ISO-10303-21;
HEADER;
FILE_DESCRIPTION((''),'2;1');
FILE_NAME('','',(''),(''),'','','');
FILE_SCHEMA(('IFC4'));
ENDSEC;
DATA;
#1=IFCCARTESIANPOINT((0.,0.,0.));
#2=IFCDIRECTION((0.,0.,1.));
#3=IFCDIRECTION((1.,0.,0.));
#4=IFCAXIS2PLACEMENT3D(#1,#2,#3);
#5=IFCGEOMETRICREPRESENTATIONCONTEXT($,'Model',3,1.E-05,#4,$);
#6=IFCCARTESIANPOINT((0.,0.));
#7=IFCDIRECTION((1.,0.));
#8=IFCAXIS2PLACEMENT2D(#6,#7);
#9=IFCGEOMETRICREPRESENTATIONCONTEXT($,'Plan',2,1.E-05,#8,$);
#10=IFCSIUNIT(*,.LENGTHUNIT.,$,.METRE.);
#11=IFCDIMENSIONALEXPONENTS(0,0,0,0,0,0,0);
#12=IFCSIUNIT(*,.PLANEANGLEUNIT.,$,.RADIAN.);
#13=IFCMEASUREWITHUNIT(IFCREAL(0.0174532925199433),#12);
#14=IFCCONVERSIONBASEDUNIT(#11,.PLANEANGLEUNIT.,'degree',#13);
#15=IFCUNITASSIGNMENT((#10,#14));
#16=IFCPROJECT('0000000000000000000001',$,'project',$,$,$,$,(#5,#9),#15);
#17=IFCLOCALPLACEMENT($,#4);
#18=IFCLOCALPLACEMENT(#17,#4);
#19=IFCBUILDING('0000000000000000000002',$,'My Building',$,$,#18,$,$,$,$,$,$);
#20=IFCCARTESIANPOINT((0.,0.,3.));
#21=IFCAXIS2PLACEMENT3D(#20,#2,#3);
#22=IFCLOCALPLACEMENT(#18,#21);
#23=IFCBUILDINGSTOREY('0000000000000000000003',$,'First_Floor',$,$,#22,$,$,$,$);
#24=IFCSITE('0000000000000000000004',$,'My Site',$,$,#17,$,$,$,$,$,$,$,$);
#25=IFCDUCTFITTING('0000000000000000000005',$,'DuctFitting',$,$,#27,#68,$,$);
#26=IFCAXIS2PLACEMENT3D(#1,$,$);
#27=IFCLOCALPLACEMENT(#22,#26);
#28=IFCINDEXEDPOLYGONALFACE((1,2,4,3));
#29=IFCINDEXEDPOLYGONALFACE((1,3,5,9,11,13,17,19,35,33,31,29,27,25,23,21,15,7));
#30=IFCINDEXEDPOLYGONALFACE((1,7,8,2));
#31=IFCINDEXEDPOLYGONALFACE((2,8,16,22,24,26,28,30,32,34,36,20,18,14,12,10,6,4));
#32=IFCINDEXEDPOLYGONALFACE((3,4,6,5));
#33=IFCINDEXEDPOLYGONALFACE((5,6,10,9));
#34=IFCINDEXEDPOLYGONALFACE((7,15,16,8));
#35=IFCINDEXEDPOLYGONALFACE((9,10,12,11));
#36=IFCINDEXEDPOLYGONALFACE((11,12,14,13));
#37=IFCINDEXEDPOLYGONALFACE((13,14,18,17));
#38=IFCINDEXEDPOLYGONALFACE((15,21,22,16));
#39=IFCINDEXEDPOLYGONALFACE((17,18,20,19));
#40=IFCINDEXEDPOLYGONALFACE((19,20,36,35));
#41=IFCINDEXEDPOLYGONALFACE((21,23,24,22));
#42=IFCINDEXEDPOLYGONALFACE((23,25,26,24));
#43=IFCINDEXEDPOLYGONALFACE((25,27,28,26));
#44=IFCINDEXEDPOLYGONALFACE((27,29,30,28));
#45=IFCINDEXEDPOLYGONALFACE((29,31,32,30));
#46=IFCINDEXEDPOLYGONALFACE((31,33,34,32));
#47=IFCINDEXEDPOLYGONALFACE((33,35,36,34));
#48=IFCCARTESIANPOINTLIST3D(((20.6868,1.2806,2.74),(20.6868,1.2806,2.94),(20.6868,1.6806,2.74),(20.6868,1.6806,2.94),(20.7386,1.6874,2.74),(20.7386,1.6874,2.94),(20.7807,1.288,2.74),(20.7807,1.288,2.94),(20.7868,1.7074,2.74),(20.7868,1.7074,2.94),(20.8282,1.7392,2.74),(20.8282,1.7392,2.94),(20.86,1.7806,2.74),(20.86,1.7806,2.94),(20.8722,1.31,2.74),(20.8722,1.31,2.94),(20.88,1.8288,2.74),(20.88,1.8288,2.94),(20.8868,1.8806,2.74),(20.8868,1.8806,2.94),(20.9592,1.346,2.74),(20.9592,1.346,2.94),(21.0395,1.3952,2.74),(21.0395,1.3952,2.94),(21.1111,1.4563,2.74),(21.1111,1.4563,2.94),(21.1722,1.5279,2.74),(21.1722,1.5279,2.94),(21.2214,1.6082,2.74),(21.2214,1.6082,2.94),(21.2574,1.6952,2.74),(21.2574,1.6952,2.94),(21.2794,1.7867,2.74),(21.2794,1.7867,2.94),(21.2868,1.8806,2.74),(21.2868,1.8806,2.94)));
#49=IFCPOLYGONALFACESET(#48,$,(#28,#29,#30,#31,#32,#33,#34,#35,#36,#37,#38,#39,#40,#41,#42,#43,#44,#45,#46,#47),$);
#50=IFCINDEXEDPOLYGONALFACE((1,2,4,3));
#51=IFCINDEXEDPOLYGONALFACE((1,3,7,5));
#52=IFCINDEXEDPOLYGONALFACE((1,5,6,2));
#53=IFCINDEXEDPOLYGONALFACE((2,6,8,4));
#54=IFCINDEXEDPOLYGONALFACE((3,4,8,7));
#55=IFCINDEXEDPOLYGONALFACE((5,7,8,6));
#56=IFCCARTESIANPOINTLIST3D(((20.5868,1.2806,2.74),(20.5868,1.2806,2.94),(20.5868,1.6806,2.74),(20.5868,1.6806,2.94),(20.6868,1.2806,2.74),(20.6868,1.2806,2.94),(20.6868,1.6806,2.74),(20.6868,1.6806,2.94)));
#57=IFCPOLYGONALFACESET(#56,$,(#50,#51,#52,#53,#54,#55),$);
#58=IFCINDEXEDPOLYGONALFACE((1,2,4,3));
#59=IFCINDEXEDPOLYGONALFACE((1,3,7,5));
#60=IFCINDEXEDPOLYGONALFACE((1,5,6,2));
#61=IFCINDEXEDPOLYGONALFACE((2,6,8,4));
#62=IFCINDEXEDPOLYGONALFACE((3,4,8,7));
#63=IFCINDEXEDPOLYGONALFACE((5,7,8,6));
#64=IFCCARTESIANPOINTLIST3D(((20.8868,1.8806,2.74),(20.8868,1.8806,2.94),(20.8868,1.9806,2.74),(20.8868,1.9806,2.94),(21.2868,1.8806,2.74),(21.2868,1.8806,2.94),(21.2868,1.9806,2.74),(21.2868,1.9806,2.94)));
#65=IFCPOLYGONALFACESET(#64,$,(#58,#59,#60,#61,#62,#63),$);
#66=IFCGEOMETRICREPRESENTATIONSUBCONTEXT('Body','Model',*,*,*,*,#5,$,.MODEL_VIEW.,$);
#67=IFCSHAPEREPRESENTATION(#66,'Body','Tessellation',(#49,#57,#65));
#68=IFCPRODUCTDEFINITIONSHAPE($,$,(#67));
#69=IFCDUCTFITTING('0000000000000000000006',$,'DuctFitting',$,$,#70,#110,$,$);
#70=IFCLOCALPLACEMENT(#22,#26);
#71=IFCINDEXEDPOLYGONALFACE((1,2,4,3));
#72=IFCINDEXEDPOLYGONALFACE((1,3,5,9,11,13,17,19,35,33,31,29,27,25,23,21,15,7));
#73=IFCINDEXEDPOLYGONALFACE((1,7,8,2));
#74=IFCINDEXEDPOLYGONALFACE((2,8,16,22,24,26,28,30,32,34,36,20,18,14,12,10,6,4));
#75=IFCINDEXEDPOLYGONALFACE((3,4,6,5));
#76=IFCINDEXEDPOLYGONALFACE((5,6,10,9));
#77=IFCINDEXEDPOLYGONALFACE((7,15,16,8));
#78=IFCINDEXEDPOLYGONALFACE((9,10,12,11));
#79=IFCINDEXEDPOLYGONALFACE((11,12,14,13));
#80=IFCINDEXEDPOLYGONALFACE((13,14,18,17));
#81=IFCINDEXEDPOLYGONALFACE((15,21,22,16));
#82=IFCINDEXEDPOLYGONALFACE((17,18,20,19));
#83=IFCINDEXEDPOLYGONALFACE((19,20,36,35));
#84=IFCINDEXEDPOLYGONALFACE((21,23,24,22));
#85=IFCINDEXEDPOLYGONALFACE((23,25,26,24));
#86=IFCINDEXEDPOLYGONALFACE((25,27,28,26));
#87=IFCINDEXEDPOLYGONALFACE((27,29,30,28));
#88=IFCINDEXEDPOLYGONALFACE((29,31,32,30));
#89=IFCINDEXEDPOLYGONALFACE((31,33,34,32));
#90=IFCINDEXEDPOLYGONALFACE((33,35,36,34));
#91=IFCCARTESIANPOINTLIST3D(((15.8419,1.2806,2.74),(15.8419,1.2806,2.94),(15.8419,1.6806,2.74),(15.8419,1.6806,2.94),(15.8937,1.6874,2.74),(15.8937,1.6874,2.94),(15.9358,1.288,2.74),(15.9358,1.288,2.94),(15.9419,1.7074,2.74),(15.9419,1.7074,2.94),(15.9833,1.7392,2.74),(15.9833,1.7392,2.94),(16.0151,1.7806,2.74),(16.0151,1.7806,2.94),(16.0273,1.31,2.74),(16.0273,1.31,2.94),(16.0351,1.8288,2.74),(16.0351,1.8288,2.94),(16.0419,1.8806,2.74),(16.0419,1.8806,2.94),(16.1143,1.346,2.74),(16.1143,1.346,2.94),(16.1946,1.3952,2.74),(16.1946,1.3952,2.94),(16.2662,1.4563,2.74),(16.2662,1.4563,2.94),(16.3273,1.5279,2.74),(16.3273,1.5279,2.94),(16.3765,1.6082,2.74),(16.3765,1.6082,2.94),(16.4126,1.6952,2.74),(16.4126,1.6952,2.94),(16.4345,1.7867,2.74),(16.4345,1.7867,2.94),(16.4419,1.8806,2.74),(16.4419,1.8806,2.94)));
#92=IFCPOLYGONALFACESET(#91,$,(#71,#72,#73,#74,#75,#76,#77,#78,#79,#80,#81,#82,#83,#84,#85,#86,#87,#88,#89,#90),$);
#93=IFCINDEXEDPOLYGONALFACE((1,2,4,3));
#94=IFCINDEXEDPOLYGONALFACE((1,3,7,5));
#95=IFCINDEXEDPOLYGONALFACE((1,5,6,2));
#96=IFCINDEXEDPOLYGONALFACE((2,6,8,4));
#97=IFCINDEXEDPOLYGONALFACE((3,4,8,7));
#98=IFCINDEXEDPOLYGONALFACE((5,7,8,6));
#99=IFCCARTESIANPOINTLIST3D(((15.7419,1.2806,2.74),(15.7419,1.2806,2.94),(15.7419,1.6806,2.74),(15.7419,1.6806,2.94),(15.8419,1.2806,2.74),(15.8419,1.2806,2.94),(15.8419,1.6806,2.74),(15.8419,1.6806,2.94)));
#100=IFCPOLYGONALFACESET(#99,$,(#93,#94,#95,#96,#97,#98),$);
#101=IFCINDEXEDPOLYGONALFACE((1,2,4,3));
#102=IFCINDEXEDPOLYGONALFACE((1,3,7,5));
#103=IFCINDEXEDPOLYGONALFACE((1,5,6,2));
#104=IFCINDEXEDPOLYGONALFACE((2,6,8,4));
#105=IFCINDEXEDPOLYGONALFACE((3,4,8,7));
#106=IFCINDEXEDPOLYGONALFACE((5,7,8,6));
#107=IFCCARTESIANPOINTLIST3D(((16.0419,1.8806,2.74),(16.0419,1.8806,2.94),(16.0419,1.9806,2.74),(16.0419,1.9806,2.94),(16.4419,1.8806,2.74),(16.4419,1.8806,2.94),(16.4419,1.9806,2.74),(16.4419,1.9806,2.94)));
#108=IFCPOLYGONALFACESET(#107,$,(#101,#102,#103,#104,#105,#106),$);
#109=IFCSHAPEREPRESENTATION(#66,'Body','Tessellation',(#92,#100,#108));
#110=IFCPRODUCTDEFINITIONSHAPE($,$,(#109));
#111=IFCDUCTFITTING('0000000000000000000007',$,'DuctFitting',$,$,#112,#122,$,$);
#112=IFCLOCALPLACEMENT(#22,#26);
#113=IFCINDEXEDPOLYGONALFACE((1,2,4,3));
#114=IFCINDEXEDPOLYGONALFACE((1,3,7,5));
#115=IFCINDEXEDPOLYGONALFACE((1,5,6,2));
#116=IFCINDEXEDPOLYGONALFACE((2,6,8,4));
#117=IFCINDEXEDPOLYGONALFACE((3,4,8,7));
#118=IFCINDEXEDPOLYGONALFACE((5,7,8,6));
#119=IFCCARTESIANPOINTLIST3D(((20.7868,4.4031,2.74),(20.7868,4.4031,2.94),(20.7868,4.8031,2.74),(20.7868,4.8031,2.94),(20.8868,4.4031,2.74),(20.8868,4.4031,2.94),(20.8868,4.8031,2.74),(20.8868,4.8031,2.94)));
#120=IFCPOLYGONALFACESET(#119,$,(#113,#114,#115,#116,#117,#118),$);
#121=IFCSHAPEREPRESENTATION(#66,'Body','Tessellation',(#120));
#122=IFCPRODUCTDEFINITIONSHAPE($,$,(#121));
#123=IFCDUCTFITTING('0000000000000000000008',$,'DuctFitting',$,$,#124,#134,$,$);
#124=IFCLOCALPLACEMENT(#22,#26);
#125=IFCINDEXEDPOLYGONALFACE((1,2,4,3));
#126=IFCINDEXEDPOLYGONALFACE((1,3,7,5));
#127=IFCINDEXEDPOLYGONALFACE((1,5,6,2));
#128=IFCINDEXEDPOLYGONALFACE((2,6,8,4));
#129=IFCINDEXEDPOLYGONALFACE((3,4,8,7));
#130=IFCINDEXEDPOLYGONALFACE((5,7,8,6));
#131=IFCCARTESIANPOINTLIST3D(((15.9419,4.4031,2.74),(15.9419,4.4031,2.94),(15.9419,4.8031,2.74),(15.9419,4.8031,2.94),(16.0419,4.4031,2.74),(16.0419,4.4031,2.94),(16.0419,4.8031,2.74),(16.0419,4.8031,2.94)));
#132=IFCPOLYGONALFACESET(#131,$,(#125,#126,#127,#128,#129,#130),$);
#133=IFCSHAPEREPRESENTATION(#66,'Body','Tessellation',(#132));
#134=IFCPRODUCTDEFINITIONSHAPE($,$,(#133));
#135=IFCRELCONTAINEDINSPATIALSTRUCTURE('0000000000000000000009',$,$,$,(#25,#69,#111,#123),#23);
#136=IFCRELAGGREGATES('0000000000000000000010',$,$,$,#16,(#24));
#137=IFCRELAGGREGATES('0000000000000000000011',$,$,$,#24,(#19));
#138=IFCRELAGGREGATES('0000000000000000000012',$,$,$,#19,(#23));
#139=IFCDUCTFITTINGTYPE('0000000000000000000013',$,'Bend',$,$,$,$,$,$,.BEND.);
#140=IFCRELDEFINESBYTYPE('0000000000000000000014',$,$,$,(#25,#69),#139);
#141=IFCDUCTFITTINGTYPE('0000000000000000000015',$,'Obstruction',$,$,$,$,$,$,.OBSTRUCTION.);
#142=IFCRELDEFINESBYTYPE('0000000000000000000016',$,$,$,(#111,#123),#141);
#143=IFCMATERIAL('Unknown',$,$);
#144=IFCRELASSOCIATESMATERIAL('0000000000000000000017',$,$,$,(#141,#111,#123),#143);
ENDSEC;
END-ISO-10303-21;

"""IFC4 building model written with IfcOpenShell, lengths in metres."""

from ifc_helpers import new_model, entity, si_unit, converted_unit, frame, origin_with_axes, origin_2d_with_axis, place, context, subcontext, project, spatial, line, arc, indexed_curve, rectangle, outline, extrude, source, transform, mapped, material, material_profile, profile_set, profile_usage, type_object, type_shapes, element, save


model = new_model("IFC4")

# Units and contexts
model_context = context("Model", 3, precision=1e-05, world=origin_with_axes())
plan_context = context("Plan", 2, precision=1e-05, world=origin_2d_with_axis())
body_context = subcontext(model_context, "Body", "Model", "MODEL_VIEW")
ifc_project = project(units=[si_unit("LENGTHUNIT", "METRE"), converted_unit("PLANEANGLEUNIT", "degree", entity("IfcReal", 0.0174532925199433), si_unit("PLANEANGLEUNIT", "RADIAN"), dimensions=[0, 0, 0, 0, 0, 0, 0])], contexts=[model_context, plan_context])

# Site, building, storey
site_placement = place(None, origin_with_axes())
site = spatial("IfcSite", under=ifc_project, at=site_placement, Name="My Site")
building_placement = place(site_placement, origin_with_axes())
building = spatial("IfcBuilding", under=site, at=building_placement, Name="My Building")
storey_placement = place(building_placement, frame((0.0, 0.0, 3.0), z_axis=(0.0, 0.0, 1.0), x_axis=(1.0, 0.0, 0.0)))
storey = spatial("IfcBuildingStorey", under=building, at=storey_placement, Name="First_Floor")

# Shared definitions
ifc_material = material(Name="Unknown")

# Duct fittings
duct_fitting_type_1 = type_object("IfcDuctFittingType", Name="Bend", PredefinedType="BEND")
shared_shape_1 = source(origin_with_axes(), body_context, "Body", "SweptSolid", [
    extrude(outline(indexed_curve([(0.2, 0.0), (0.2586, -0.1414), (0.4, -0.2), (0.4, -0.6), (-0.0243, -0.4243), (-0.2, 0.0)], segments=[arc(1, 2, 3), line(3, 4), arc(4, 5, 6), line(6, 1)])), frame((0.0, -0.1, -0.1), z_axis=(0.0, -1.0, 0.0), x_axis=(1.0, 0.0, 0.0)), (0.0, 0.0, -1.0), 0.2),
    extrude(rectangle(XDim=0.4, YDim=0.2), origin_with_axes(), (0.0, 0.0, -1.0), 0.1),
    extrude(rectangle(XDim=0.4, YDim=0.2), frame((0.4, 0.0, -0.5), z_axis=(1.0, 0.0, 0.0), x_axis=(0.0, 0.0, 1.0)), (0.0, 0.0, 1.0), 0.1),
])
type_shapes(duct_fitting_type_1, [shared_shape_1])
for number, where, z_axis, x_axis, name in (
    (1, (20.5868, 1.4806, 2.84), (-1.0, 0.0, -0.000001), (0.0, 1.0, 0.0), "DuctFitting"),
    (2, (15.7419, 1.4806, 2.84), (-1.0, 0.0, -0.000001), (0.0, 1.0, 0.0), "DuctFitting"),
):
    element("IfcDuctFitting", number, at=place(storey_placement, frame(where, z_axis=z_axis, x_axis=x_axis)), inside=storey, type_object=duct_fitting_type_1, Name=name, context=body_context, shape_type="MappedRepresentation", body=[
        mapped(shared_shape_1, transform((0.0, 0.0, 0.0), x_axis=(1.0, 0.0, 0.0), y_axis=(0.0, 1.0, 0.0), z_axis=(0.0, 0.0, 1.0), scale=1.0)),
    ])
ifc_material_profile_1 = material_profile(ifc_material, rectangle(XDim=0.4, YDim=0.2))
ifc_profile_set_1 = profile_set([ifc_material_profile_1])
ifc_profile_usage_1 = profile_usage(ifc_profile_set_1, cardinal=5)
duct_fitting_type_2 = type_object("IfcDuctFittingType", Name="Obstruction", PredefinedType="OBSTRUCTION", material=ifc_profile_set_1)
duct_fitting_1_placement = place(storey_placement, frame((20.8868, 4.6031, 2.84), z_axis=(-1.0, 0.0, 0.0), x_axis=(0.0, -1.0, 0.0)))
element("IfcDuctFitting", 3, at=duct_fitting_1_placement, inside=storey, type_object=duct_fitting_type_2, material=ifc_profile_usage_1, Name="DuctFitting", context=body_context, shape_type="SweptSolid", body=[
    extrude(rectangle(XDim=0.4, YDim=0.2), origin_with_axes(), (0.0, 0.0, 1.0), 0.1),
])
ifc_profile_usage_2 = profile_usage(ifc_profile_set_1, cardinal=5)
duct_fitting_2_placement = place(storey_placement, frame((16.0419, 4.6031, 2.84), z_axis=(-1.0, 0.0, 0.0), x_axis=(0.0, -1.0, 0.0)))
element("IfcDuctFitting", 4, at=duct_fitting_2_placement, inside=storey, type_object=duct_fitting_type_2, material=ifc_profile_usage_2, Name="DuctFitting", context=body_context, shape_type="SweptSolid", body=[
    extrude(rectangle(XDim=0.4, YDim=0.2), origin_with_axes(), (0.0, 0.0, 1.0), 0.1),
])

save(model, "model.ifc")
